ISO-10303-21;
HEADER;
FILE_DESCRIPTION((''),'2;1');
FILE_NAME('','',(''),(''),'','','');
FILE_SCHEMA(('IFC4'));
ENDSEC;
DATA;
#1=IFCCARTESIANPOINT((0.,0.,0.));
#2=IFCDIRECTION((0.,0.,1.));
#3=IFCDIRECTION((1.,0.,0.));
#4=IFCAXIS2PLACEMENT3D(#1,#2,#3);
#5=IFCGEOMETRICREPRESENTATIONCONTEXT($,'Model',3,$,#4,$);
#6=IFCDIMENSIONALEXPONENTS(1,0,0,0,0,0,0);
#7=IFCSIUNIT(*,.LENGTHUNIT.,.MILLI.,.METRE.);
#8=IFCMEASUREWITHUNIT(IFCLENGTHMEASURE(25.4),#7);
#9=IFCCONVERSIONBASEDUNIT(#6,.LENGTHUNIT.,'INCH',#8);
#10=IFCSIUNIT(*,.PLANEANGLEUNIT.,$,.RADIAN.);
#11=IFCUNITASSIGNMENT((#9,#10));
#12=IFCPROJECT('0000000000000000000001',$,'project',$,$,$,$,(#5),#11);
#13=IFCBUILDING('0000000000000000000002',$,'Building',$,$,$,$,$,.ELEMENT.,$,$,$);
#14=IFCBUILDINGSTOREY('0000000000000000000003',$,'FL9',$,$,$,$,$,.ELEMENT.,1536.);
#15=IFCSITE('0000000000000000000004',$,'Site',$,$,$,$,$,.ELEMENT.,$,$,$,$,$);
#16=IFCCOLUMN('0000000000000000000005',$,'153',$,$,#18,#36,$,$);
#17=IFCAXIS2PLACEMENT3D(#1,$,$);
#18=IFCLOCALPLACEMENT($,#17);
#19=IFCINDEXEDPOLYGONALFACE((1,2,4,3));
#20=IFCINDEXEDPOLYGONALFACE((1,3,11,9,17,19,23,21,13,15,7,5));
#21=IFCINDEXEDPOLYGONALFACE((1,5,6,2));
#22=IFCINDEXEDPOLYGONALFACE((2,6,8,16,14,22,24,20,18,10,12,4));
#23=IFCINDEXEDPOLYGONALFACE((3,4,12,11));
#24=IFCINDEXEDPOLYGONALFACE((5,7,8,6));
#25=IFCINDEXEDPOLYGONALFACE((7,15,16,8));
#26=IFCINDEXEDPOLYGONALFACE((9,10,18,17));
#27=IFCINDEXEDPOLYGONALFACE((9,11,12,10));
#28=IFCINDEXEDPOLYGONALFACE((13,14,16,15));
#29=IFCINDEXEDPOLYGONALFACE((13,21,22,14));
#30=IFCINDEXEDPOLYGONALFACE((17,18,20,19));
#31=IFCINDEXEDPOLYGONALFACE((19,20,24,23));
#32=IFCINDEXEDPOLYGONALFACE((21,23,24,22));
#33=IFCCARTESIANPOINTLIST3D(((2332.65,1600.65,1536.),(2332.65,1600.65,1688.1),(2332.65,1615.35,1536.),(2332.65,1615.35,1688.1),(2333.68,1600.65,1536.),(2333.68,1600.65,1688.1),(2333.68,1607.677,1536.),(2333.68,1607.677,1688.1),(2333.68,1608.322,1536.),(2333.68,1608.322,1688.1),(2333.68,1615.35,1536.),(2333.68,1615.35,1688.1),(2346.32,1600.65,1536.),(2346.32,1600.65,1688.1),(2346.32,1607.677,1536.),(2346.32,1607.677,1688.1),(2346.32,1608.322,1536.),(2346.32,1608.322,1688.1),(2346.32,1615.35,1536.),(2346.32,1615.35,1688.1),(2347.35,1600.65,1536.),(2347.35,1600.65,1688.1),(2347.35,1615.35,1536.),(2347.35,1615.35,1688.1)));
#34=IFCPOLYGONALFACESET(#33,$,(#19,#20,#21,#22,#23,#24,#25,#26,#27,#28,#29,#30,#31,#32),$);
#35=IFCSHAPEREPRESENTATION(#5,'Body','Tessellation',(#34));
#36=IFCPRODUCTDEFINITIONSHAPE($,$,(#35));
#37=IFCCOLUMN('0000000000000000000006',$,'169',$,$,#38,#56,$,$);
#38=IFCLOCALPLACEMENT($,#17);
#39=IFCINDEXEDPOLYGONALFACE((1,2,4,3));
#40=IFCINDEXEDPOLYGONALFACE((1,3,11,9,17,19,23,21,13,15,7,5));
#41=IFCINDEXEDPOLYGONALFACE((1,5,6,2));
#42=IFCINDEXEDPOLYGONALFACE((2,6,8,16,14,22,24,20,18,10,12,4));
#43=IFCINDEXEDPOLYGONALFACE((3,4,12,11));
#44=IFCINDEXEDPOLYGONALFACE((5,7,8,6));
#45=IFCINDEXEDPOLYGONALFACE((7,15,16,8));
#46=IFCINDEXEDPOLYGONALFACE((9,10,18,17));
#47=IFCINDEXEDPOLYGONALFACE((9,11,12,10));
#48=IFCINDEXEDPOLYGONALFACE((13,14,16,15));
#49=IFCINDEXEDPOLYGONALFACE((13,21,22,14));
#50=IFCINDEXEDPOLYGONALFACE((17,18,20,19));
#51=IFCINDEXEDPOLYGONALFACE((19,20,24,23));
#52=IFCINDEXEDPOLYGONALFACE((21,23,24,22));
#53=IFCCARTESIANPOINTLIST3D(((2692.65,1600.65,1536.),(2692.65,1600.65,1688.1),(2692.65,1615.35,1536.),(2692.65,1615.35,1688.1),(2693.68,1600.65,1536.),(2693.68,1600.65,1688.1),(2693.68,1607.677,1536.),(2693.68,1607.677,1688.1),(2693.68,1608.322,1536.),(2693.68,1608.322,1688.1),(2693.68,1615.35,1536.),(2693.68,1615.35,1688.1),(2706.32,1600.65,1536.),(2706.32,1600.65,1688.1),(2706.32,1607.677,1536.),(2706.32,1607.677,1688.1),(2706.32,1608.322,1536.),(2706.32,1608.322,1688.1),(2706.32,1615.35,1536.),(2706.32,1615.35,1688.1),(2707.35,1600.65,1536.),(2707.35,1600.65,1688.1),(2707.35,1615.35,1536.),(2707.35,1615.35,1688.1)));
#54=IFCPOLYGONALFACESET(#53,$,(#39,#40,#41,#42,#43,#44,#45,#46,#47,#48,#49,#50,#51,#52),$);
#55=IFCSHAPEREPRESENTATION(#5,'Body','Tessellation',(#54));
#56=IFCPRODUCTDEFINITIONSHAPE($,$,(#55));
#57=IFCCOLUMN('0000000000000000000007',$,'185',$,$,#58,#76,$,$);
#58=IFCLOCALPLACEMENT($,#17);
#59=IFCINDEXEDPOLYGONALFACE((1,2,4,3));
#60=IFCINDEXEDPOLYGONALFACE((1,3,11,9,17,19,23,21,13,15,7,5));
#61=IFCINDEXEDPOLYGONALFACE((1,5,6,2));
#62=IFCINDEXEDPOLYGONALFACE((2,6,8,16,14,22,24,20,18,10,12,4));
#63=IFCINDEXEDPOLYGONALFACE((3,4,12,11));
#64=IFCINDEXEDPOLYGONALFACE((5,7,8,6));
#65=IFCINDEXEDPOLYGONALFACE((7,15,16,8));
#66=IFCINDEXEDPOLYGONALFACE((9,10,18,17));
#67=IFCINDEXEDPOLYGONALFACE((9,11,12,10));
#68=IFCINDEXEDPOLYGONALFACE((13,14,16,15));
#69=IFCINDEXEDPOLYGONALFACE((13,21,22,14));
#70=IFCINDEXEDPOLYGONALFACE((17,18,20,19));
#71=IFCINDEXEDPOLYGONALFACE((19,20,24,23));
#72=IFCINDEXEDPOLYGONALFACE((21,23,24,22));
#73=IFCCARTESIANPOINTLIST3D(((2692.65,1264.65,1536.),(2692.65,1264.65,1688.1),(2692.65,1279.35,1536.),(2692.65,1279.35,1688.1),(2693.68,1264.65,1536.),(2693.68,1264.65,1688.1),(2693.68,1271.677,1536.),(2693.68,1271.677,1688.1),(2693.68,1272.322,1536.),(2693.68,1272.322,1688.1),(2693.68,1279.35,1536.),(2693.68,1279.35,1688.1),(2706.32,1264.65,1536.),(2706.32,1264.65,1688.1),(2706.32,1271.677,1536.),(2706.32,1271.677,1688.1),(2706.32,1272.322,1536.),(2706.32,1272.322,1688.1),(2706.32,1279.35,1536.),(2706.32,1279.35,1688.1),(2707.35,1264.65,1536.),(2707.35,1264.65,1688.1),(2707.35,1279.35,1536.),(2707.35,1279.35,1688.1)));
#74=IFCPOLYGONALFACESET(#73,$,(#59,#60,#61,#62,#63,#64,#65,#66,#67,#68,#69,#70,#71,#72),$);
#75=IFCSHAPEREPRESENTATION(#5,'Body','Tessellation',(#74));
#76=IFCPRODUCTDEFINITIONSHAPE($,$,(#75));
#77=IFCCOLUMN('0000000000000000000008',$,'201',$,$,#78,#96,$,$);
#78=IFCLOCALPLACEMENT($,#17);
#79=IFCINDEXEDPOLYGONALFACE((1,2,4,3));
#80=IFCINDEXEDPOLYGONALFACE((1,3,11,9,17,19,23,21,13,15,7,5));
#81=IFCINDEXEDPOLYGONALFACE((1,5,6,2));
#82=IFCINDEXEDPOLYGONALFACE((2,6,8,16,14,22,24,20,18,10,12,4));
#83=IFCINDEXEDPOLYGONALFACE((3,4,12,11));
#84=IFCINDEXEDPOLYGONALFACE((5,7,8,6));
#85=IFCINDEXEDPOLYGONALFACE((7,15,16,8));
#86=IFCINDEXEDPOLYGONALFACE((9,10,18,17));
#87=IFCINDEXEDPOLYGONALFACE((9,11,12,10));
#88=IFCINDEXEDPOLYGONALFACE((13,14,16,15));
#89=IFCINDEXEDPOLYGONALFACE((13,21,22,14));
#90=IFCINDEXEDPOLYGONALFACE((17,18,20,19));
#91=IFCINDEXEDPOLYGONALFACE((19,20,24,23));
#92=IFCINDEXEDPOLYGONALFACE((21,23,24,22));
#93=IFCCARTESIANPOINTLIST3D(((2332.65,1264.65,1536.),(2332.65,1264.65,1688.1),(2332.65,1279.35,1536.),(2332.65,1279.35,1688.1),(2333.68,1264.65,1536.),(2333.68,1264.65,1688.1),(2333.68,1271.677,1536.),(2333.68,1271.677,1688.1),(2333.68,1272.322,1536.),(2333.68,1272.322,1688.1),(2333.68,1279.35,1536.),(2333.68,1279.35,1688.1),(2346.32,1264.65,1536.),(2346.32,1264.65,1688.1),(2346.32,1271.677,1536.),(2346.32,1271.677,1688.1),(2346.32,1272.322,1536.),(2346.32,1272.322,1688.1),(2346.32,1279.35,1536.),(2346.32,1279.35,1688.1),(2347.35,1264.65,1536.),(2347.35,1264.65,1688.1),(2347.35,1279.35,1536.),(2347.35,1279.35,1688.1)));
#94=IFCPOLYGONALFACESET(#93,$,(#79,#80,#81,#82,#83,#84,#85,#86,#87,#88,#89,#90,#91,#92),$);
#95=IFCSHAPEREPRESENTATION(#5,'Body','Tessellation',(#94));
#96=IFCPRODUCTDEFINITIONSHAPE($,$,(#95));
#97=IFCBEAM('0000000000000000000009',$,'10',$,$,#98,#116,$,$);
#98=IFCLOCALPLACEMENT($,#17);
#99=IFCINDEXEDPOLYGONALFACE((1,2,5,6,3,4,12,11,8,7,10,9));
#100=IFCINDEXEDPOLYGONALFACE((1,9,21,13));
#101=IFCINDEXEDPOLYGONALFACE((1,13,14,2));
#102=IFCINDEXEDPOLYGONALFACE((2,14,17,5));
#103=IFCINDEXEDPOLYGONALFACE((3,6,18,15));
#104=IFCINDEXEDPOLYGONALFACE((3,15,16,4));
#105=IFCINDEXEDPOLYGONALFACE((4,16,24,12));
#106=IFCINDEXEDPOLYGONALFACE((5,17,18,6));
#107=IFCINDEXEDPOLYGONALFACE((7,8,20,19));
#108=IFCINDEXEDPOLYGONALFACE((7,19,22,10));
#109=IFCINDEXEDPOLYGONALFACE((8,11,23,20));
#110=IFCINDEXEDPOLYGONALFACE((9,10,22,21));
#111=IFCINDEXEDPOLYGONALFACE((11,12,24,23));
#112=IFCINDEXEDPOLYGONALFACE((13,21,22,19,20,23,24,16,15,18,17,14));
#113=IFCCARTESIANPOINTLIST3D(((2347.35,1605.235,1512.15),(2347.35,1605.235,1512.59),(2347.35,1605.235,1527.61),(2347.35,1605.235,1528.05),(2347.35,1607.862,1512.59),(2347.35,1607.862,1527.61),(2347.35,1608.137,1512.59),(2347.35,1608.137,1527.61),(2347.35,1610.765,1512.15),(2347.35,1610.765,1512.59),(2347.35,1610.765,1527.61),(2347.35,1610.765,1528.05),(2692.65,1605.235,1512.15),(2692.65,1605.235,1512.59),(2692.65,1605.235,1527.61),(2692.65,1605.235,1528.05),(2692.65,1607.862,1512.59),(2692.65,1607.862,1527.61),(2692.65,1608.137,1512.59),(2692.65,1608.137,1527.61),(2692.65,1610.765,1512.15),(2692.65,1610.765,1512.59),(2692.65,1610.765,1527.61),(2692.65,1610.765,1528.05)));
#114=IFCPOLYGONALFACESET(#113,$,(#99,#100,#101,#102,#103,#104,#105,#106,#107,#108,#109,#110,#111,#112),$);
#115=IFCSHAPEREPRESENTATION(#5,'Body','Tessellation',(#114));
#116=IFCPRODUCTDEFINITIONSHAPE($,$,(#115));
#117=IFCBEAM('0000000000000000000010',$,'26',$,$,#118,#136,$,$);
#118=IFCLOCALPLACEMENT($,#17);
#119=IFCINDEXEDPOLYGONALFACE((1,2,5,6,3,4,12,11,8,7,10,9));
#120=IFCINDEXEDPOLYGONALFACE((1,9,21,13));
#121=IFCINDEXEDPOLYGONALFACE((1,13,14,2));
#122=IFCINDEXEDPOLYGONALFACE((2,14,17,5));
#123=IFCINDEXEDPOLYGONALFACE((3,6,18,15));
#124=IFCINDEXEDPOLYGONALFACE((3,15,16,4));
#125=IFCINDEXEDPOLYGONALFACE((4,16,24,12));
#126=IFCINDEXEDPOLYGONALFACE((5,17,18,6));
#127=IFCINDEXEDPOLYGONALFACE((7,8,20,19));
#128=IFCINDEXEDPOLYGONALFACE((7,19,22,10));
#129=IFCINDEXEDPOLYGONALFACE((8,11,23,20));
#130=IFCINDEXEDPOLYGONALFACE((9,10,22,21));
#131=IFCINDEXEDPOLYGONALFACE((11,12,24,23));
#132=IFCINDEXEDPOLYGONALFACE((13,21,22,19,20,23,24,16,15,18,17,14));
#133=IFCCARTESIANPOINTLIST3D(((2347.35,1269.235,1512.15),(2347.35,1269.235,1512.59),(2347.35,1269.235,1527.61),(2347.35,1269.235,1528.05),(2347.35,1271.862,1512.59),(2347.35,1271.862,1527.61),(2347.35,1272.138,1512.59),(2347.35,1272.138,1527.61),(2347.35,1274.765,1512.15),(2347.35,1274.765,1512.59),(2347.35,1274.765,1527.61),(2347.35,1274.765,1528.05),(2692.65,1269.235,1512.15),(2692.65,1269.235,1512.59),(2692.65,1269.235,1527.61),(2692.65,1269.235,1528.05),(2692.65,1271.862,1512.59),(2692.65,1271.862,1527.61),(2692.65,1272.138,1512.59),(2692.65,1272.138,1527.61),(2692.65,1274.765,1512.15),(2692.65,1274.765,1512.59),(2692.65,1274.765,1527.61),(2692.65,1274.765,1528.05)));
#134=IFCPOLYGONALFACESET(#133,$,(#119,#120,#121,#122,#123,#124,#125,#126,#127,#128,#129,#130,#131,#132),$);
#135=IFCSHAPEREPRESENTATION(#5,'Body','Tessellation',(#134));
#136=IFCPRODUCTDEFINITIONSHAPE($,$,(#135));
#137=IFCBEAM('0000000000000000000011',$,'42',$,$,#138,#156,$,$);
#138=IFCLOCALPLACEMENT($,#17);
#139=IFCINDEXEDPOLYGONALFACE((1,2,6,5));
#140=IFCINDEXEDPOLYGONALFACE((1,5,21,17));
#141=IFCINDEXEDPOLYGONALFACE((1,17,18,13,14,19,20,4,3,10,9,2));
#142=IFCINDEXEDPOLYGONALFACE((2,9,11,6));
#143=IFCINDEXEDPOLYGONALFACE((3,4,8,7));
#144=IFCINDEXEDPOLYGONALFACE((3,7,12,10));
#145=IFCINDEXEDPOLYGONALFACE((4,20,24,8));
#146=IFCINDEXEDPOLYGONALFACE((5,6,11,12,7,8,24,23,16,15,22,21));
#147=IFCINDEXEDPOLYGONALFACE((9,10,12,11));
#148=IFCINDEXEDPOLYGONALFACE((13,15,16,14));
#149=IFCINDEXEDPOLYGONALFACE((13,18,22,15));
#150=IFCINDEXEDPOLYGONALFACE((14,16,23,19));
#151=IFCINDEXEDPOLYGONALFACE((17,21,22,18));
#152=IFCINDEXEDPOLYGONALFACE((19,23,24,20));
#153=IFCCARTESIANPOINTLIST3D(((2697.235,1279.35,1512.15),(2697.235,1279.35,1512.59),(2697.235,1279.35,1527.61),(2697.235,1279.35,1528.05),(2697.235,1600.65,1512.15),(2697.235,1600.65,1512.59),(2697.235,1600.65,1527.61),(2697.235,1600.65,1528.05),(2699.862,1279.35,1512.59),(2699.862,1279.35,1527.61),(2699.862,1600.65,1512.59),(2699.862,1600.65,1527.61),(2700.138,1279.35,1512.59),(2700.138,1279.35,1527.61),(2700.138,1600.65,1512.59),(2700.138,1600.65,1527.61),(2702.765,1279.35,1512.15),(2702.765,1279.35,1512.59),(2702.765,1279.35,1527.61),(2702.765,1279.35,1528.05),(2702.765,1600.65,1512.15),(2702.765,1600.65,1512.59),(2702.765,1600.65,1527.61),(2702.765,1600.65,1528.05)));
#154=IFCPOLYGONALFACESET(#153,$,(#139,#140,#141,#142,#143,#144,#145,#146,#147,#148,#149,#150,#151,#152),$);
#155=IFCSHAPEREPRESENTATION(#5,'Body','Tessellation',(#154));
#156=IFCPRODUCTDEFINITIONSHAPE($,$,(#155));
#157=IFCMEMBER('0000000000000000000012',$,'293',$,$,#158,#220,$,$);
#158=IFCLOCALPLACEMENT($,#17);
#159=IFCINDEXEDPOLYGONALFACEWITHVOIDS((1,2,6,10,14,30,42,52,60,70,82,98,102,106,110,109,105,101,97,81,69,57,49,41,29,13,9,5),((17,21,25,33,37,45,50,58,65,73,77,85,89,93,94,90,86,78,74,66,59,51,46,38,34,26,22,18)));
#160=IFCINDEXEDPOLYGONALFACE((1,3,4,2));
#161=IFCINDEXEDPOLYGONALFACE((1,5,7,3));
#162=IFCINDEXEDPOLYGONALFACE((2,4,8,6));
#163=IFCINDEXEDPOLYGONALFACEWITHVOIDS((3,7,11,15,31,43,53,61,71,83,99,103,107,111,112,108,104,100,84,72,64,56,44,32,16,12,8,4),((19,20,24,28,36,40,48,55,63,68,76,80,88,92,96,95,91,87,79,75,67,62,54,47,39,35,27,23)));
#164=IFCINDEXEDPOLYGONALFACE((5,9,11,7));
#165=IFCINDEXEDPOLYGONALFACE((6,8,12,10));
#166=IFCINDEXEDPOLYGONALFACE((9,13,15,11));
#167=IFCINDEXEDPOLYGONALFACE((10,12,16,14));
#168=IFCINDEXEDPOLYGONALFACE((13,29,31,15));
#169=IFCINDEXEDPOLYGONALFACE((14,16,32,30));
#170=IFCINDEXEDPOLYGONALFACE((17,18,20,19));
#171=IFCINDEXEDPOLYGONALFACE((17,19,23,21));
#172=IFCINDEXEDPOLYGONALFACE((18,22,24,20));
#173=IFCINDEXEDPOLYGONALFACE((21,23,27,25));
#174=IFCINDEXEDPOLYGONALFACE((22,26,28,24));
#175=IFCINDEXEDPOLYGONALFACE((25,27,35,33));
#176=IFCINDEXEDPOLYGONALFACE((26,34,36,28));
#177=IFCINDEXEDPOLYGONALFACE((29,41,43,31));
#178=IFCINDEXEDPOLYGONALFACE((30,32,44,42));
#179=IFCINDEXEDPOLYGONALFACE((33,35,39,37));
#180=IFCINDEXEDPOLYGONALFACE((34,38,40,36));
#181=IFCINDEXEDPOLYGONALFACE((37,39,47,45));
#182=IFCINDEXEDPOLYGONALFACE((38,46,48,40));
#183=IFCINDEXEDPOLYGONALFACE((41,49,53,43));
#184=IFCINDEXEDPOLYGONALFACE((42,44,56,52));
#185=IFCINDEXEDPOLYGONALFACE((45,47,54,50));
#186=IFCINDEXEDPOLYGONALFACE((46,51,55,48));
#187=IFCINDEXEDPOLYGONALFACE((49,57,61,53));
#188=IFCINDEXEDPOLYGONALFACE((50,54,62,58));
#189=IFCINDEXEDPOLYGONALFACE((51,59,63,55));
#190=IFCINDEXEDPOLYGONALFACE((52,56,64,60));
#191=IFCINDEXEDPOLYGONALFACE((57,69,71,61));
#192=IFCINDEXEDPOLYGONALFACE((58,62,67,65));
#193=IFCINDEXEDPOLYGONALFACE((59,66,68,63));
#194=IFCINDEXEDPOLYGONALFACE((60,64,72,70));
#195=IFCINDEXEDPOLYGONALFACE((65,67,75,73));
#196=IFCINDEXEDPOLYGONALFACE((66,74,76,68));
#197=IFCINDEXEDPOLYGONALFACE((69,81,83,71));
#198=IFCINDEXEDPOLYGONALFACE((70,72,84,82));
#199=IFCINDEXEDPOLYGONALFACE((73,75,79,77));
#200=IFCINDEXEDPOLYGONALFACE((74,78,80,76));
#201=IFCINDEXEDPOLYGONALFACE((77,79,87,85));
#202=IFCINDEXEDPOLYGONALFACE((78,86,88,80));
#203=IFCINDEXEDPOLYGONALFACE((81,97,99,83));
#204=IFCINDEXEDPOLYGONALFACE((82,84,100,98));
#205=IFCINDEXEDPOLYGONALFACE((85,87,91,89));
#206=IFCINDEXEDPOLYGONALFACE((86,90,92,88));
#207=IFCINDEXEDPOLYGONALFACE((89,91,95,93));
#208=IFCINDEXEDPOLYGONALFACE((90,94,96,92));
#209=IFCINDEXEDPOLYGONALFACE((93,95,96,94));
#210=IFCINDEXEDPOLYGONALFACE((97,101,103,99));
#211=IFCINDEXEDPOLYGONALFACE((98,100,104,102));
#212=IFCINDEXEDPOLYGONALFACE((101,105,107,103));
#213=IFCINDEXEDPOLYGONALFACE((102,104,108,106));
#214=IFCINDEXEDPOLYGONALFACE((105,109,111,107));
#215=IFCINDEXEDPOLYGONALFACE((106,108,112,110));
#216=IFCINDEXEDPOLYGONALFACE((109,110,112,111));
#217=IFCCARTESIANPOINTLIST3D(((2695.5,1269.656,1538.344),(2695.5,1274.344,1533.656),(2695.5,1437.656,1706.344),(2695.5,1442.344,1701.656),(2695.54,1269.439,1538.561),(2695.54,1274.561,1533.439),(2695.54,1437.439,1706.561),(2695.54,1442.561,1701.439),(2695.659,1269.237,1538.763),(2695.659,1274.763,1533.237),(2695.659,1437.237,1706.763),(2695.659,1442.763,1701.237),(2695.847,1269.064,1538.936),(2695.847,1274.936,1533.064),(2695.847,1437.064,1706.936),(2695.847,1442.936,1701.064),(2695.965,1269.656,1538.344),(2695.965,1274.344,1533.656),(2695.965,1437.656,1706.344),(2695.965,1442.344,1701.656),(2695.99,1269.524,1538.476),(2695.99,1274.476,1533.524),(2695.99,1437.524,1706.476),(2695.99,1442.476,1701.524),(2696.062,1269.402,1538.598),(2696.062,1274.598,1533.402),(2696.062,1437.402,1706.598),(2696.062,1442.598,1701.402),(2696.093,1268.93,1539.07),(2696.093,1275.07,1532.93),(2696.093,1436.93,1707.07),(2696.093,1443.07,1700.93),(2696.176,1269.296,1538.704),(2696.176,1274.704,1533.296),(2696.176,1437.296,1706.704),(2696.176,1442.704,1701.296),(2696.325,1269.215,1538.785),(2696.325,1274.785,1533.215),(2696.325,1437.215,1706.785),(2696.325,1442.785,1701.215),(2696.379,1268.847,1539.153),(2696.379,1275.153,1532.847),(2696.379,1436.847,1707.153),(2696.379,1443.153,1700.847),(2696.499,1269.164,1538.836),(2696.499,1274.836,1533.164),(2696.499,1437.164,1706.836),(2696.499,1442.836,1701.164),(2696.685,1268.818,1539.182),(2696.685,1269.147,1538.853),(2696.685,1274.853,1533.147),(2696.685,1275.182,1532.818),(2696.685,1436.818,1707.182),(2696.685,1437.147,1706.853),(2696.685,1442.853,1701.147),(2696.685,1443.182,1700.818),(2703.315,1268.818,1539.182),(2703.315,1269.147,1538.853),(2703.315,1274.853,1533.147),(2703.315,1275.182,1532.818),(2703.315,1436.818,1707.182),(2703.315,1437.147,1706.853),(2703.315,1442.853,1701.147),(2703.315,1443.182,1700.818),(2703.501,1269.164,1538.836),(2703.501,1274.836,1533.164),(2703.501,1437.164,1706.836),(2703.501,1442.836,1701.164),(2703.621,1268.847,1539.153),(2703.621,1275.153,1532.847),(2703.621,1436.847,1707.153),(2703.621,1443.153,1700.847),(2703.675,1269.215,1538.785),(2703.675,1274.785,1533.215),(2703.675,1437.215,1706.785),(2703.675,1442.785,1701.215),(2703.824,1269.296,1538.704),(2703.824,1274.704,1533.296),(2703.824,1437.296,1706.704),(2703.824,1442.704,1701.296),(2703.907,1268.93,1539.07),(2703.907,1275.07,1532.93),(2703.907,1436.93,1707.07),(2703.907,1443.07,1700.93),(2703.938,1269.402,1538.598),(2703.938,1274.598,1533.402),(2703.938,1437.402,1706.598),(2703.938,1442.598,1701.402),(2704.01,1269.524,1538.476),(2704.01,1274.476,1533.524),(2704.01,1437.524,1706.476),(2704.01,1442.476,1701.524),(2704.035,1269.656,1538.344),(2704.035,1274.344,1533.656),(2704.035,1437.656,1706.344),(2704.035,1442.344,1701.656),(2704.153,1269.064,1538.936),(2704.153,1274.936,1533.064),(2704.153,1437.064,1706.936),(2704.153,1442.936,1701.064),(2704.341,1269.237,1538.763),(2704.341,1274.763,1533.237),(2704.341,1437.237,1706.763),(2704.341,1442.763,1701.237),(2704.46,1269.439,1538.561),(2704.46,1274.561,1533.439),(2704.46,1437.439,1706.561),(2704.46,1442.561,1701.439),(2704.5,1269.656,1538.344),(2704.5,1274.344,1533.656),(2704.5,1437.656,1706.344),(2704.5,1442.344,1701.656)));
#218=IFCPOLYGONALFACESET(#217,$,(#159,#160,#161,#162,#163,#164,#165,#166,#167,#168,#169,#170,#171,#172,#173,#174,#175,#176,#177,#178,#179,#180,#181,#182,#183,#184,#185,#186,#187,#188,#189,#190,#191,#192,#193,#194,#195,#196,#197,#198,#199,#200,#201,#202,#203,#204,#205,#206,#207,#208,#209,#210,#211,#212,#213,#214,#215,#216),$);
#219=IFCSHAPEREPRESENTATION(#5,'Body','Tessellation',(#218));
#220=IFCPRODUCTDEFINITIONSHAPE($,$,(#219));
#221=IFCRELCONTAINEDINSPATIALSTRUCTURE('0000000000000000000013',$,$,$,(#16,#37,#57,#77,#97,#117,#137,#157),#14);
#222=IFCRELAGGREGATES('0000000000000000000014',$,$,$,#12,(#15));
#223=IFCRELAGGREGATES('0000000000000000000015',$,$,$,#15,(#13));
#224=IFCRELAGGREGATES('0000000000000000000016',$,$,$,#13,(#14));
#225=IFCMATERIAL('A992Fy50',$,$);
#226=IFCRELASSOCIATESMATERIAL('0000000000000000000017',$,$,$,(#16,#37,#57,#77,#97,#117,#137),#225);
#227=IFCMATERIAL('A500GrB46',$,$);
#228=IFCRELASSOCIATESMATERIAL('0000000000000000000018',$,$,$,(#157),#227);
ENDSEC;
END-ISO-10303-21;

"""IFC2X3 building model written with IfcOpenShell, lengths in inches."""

from ifc_helpers import new_model, entity, si_unit, converted_unit, frame, origin_with_axes, origin_2d_with_axis, place, context, project, spatial, hollow_rectangle, i_section, transform_2d, derived_profile, extrude, material, element, save


model = new_model("IFC2X3")

# Units and contexts
model_context = context("Model", 3, world=origin_with_axes())
ifc_project = project(units=[converted_unit("LENGTHUNIT", "INCH", entity("IfcLengthMeasure", 25.4), si_unit("LENGTHUNIT", "METRE", prefix="MILLI"), dimensions=[1, 0, 0, 0, 0, 0, 0]), si_unit("PLANEANGLEUNIT", "RADIAN")], contexts=[model_context])

# Site, building, storey
site = spatial("IfcSite", under=ifc_project, Name="Site", CompositionType="ELEMENT")
building = spatial("IfcBuilding", under=site, Name="Building", CompositionType="ELEMENT")
storey = spatial("IfcBuildingStorey", under=building, Name="FL9", CompositionType="ELEMENT", Elevation=1536.0)

# Columns
ifc_material_1 = material(Name="A992Fy50")
for number, where, z_axis, x_axis, name in (
    (1, (2340.0, 1608.0, 1536.0), (0.0, 0.0, 1.0), (0.0, -1.0, 0.0), "153"),
    (2, (2700.0, 1608.0, 1536.0), (0.0, 0.0, 1.0), (0.0, -1.0, 0.0), "169"),
    (3, (2700.0, 1272.0, 1536.0), (0.0, 0.0, 1.0), (0.0, -1.0, 0.0), "185"),
    (4, (2340.0, 1272.0, 1536.0), (0.0, 0.0, 1.0), (0.0, -1.0, 0.0), "201"),
):
    element("IfcColumn", number, at=place(None, frame(where, z_axis=z_axis, x_axis=x_axis)), inside=storey, material=ifc_material_1, Name=name, context=model_context, shape_type="SweptSolid", body=[
        extrude(i_section(OverallWidth=14.7, OverallDepth=14.7, WebThickness=0.645, FlangeThickness=1.03, at=origin_2d_with_axis()), origin_with_axes(), (0.0, 0.0, 1.0), 152.1),
    ])

# Beams
for number, where, z_axis, x_axis, name in (
    (5, (2347.35, 1608.0, 1536.0), (1.0, 0.0, 0.0), (0.0, 1.0, 0.0), "10"),
    (6, (2347.35, 1272.0, 1536.0), (1.0, 0.0, 0.0), (0.0, 1.0, 0.0), "26"),
):
    element("IfcBeam", number, at=place(None, frame(where, z_axis=z_axis, x_axis=x_axis)), inside=storey, material=ifc_material_1, Name=name, context=model_context, shape_type="SweptSolid", body=[
        extrude(derived_profile(i_section(OverallWidth=5.53, OverallDepth=15.9, WebThickness=0.275, FlangeThickness=0.44, at=origin_2d_with_axis()), transform_2d((0.0, -7.95))), origin_with_axes(), (0.0, 0.0, 1.0), 345.3),
    ])
beam_placement = place(None, frame((2700.0, 1279.35, 1536.0), z_axis=(0.0, 1.0, 0.0), x_axis=(-1.0, 0.0, 0.0)))
element("IfcBeam", 7, at=beam_placement, inside=storey, material=ifc_material_1, Name="42", context=model_context, shape_type="SweptSolid", body=[
    extrude(derived_profile(i_section(OverallWidth=5.53, OverallDepth=15.9, WebThickness=0.275, FlangeThickness=0.44, at=origin_2d_with_axis()), transform_2d((0.0, -7.95))), origin_with_axes(), (0.0, 0.0, 1.0), 321.3),
])

# Member
ifc_material_2 = material(Name="A500GrB46")
for number, where, z_axis, x_axis, name in (
    (8, (2700.0, 1272.0, 1536.0), (0.0, 0.707107, 0.707107), (-1.0, 0.0, 0.0), "293"),
):
    element("IfcMember", number, at=place(None, frame(where, z_axis=z_axis, x_axis=x_axis)), inside=storey, material=ifc_material_2, Name=name, context=model_context, shape_type="SweptSolid", body=[
        extrude(hollow_rectangle(XDim=9.0, YDim=9.0, WallThickness=0.465, InnerFilletRadius=0.72, OuterFilletRadius=1.185, at=origin_2d_with_axis()), origin_with_axes(), (0.0, 0.0, 1.0), 237.588),
    ])

save(model, "model.ifc")
